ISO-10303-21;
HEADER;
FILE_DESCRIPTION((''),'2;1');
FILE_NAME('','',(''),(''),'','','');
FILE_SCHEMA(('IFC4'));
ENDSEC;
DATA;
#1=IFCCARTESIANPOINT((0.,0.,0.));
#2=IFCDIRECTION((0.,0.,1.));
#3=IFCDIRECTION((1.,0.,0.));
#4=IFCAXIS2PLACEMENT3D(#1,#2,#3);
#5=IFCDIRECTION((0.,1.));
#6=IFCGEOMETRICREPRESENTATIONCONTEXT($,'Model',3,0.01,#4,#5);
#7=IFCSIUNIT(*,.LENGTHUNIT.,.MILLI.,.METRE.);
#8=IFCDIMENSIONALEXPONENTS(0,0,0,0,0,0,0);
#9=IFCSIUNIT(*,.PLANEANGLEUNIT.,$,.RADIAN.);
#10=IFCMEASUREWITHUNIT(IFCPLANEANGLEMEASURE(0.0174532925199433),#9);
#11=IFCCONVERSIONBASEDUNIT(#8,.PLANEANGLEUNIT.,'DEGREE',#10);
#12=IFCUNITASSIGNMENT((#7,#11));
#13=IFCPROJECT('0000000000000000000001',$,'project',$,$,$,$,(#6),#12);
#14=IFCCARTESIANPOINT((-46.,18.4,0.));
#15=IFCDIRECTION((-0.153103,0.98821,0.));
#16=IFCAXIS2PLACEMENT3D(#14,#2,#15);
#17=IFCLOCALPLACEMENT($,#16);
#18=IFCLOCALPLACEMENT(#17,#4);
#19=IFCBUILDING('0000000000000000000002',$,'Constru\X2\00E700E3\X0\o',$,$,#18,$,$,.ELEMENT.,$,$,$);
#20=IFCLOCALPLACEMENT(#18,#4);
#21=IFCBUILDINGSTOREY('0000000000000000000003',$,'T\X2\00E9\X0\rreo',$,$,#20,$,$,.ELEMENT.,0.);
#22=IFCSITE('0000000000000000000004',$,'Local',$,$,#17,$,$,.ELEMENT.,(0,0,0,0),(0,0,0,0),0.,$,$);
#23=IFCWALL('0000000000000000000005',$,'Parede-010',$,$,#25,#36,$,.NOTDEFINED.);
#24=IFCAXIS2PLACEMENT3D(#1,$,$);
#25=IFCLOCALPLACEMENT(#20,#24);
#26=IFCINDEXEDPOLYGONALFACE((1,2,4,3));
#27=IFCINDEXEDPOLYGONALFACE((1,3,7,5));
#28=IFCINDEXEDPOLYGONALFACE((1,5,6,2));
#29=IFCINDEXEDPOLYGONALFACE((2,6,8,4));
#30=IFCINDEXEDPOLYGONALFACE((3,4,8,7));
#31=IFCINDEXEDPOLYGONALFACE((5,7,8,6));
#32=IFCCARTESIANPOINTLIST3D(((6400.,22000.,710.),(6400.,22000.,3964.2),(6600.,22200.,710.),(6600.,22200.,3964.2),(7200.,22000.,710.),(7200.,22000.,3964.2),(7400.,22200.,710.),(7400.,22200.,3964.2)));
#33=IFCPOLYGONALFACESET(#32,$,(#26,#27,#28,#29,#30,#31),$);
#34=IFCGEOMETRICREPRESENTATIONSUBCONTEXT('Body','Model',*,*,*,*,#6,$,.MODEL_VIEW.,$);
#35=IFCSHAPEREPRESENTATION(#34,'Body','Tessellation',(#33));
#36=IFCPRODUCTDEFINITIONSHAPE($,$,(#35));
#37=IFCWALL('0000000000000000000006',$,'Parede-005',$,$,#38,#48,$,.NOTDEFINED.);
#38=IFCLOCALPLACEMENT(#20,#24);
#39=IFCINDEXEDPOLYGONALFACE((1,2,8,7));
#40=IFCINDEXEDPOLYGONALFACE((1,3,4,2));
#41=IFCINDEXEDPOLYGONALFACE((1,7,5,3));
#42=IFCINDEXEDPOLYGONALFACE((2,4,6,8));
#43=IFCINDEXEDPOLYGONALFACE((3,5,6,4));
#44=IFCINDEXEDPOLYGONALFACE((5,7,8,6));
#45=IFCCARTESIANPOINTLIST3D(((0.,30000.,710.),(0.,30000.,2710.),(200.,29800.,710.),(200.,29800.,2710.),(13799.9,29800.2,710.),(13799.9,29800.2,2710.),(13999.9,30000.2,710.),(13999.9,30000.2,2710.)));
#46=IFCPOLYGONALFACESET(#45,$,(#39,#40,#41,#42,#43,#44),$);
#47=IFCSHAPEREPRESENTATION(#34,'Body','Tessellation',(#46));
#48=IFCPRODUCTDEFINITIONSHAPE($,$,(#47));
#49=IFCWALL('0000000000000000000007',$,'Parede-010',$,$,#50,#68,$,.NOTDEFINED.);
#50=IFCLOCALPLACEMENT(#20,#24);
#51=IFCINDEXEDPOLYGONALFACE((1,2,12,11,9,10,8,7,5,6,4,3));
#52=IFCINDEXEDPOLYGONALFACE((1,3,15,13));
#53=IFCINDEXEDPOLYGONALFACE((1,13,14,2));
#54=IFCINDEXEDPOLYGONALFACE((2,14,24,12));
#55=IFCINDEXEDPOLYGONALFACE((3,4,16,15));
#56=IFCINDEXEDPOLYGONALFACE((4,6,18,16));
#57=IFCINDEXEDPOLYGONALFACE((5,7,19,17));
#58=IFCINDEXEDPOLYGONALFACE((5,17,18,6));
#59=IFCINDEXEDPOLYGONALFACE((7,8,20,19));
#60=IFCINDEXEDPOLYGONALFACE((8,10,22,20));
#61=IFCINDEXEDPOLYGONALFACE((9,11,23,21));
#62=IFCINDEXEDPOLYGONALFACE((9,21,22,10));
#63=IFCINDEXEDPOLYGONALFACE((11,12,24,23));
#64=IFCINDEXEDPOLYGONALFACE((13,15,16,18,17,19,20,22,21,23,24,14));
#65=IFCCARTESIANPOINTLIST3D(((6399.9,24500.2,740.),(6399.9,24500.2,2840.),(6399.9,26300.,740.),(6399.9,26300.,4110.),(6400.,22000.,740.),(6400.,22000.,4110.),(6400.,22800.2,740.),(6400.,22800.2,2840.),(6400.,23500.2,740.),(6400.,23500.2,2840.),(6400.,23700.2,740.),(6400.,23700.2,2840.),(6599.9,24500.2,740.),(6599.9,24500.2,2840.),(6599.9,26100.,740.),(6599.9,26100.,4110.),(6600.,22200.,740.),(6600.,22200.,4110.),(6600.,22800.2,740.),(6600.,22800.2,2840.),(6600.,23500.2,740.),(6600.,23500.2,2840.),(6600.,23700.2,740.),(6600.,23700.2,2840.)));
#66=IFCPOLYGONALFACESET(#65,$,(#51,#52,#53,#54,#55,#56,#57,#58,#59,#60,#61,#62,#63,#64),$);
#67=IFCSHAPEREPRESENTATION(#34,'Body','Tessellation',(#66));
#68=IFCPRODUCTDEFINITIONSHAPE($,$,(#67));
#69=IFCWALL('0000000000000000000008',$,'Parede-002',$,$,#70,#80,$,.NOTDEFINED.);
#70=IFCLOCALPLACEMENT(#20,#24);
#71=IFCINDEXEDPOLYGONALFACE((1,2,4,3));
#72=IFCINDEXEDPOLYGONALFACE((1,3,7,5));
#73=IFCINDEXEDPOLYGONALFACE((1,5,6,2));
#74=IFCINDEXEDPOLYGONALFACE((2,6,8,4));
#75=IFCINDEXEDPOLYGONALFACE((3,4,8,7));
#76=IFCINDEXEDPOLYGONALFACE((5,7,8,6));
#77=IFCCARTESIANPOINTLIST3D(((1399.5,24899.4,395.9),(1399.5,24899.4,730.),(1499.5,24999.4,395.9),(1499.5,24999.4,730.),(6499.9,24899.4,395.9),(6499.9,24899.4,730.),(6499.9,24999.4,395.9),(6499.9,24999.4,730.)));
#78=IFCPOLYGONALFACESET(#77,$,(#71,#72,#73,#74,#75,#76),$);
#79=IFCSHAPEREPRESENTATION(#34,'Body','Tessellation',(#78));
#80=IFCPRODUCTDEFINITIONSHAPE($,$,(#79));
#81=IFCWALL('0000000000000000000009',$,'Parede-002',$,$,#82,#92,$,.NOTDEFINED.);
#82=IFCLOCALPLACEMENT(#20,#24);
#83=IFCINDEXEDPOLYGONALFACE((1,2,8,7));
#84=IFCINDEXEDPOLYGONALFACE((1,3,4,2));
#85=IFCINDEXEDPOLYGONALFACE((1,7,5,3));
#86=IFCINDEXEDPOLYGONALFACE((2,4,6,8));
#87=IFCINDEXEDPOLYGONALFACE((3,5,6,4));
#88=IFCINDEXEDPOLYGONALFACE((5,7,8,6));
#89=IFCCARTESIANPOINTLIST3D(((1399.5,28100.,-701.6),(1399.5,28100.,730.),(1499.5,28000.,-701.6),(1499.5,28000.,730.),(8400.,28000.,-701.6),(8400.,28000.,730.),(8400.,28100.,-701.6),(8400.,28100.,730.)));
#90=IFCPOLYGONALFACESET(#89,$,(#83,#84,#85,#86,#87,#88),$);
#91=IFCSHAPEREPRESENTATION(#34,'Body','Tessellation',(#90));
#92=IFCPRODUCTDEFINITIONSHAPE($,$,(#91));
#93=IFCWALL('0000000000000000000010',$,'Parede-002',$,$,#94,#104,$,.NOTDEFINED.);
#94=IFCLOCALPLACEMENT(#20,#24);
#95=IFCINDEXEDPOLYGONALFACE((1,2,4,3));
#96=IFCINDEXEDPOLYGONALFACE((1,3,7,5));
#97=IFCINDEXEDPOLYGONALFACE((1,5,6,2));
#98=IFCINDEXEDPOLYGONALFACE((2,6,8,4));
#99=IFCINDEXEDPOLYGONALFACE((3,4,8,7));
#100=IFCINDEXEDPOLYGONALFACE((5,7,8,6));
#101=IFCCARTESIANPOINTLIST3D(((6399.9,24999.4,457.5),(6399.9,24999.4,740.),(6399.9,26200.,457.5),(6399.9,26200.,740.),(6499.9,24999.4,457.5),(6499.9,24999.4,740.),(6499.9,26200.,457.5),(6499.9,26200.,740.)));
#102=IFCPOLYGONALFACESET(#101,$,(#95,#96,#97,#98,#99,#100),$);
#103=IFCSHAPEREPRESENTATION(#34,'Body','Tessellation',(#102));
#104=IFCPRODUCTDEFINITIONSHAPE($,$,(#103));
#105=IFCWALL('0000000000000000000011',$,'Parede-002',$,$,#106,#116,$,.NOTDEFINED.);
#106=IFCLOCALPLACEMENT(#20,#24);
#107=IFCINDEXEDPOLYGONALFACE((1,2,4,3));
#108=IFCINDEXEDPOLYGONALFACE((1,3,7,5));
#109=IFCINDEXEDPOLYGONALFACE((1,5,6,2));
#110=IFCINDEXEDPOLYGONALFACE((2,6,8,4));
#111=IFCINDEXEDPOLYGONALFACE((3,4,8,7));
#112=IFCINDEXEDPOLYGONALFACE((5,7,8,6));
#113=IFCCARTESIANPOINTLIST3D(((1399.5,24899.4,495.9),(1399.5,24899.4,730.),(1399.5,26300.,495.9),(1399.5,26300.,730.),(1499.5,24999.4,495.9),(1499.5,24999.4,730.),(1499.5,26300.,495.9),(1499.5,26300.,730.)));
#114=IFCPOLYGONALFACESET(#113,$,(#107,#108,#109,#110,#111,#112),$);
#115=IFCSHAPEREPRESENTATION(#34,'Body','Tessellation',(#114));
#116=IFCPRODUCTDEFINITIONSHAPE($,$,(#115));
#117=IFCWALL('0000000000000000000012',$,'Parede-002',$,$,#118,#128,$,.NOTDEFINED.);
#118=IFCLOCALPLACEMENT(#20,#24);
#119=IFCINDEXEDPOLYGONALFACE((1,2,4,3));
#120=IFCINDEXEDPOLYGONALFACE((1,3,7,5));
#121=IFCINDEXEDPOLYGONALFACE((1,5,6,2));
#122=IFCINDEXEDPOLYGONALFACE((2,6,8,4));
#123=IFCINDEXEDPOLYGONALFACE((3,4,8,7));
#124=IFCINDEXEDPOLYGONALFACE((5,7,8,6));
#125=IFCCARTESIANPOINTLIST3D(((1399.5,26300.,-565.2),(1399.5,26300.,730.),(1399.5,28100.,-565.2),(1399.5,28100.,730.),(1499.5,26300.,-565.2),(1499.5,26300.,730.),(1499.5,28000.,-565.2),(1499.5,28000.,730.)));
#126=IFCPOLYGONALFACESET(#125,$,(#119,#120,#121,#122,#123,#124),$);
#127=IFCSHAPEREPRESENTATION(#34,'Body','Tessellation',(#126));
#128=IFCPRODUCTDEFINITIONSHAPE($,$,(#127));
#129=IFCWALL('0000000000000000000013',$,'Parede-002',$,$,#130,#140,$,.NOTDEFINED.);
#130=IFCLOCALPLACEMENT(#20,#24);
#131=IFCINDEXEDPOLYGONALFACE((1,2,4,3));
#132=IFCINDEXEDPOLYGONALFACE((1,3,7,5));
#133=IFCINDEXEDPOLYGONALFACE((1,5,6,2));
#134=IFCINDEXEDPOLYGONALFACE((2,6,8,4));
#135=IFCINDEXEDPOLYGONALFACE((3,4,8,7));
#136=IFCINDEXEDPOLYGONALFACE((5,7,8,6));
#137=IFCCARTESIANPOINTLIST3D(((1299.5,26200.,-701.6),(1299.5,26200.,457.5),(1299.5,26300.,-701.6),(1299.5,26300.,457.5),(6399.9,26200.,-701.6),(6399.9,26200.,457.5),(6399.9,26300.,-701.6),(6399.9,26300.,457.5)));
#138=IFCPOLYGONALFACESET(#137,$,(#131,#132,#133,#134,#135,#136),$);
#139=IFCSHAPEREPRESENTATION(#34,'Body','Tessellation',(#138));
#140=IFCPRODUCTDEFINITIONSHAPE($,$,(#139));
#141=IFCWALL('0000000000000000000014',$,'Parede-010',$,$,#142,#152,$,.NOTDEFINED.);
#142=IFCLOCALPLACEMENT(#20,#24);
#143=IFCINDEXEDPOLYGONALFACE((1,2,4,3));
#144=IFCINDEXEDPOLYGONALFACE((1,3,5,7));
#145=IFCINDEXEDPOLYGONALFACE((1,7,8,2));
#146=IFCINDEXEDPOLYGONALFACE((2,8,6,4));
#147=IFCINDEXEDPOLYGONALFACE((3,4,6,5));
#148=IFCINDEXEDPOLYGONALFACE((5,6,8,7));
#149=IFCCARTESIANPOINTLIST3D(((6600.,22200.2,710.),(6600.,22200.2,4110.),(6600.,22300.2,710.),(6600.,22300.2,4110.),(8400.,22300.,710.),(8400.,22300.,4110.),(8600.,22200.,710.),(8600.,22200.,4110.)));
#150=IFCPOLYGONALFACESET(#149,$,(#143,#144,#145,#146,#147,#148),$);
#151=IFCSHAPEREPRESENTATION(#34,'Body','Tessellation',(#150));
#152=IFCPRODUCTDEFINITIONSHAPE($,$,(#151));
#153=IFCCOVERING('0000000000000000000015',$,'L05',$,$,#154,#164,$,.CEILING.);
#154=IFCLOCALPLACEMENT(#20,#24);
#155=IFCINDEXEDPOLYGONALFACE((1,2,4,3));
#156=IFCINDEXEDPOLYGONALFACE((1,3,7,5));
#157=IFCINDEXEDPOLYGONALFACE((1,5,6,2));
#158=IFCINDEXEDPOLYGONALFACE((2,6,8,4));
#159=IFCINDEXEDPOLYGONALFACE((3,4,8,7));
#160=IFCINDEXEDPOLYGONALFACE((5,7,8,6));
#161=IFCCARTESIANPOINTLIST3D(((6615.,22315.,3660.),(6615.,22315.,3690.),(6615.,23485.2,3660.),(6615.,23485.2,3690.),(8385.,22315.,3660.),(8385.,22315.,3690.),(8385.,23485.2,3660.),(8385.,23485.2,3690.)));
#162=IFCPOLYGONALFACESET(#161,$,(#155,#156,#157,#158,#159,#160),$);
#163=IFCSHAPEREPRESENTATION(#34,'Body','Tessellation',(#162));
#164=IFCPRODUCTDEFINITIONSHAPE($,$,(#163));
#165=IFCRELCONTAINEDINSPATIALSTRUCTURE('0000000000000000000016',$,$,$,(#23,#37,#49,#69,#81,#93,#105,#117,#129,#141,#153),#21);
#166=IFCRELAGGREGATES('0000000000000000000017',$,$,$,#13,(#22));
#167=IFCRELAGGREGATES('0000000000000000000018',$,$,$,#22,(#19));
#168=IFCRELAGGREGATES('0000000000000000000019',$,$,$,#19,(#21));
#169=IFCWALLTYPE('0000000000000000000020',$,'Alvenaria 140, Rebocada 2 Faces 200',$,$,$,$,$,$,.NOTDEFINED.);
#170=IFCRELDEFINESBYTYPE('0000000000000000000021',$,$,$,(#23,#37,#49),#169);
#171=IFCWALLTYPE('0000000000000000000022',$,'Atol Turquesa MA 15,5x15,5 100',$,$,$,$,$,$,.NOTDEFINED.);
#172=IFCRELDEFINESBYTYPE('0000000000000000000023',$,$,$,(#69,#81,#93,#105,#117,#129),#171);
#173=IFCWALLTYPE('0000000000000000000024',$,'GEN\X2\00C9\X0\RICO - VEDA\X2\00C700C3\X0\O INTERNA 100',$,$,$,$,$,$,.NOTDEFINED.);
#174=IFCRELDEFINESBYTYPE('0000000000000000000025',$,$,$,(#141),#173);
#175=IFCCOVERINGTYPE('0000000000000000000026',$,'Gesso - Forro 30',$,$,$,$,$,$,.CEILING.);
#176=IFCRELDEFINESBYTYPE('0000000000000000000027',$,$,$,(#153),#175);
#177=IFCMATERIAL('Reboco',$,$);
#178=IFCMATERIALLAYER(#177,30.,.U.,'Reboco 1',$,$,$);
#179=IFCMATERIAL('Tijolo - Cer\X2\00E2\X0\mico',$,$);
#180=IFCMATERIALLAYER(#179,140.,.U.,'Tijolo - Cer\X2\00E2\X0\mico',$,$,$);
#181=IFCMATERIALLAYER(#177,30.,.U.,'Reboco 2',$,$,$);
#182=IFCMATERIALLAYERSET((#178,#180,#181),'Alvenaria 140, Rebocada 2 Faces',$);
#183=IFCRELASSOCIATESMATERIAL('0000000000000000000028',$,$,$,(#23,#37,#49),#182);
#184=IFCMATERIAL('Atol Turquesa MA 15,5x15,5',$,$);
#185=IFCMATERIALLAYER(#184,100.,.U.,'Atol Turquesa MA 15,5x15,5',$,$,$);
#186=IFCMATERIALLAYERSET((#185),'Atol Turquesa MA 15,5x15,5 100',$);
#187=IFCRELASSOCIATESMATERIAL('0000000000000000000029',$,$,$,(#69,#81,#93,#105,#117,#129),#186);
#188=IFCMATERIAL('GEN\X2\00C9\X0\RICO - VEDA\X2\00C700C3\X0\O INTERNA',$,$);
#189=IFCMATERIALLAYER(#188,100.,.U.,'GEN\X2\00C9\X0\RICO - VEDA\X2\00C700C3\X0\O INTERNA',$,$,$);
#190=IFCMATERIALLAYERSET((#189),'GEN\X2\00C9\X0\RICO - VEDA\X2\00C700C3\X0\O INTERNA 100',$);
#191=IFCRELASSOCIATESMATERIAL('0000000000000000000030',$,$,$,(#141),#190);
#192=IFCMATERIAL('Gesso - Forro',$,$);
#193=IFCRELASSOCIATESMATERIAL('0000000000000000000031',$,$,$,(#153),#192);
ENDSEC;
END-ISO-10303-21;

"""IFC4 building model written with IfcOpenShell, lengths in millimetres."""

from ifc_helpers import new_model, entity, si_unit, converted_unit, direction, frame, origin_with_axes, origin_2d_with_axis, place, context, subcontext, project, spatial, line, indexed_curve, rectangle, outline, extrude, material, layer, layer_set, layer_usage, type_object, element, save


model = new_model("IFC4")

# Units and contexts
model_context = context("Model", 3, precision=0.01, world=origin_with_axes(), true_north=direction((0.0, 1.0)))
body_context = subcontext(model_context, "Body", "Model", "MODEL_VIEW")
ifc_project = project(units=[si_unit("LENGTHUNIT", "METRE", prefix="MILLI"), converted_unit("PLANEANGLEUNIT", "DEGREE", entity("IfcPlaneAngleMeasure", 0.0174532925199433), si_unit("PLANEANGLEUNIT", "RADIAN"), dimensions=[0, 0, 0, 0, 0, 0, 0])], contexts=[model_context])

# Site, building, storey
site_placement = place(None, frame((-46.0, 18.4, 0.0), z_axis=(0.0, 0.0, 1.0), x_axis=(-0.153103, 0.98821, 0.0)))
site = spatial("IfcSite", under=ifc_project, at=site_placement, Name="Local", CompositionType="ELEMENT", RefLatitude=(0, 0, 0, 0), RefLongitude=(0, 0, 0, 0), RefElevation=0.0)
building_placement = place(site_placement, origin_with_axes())
building = spatial("IfcBuilding", under=site, at=building_placement, Name="Construção", CompositionType="ELEMENT")
storey_placement = place(building_placement, origin_with_axes())
storey = spatial("IfcBuildingStorey", under=building, at=storey_placement, Name="Térreo", CompositionType="ELEMENT", Elevation=0.0)

# Walls
ifc_material_1 = material(Name="Reboco")
ifc_layer_1 = layer(ifc_material_1, 30.0, ventilated="UNKNOWN", Name="Reboco 1")
ifc_material_2 = material(Name="Tijolo - Cerâmico")
ifc_layer_2 = layer(ifc_material_2, 140.0, ventilated="UNKNOWN", Name="Tijolo - Cerâmico")
ifc_layer_3 = layer(ifc_material_1, 30.0, ventilated="UNKNOWN", Name="Reboco 2")
ifc_layer_set_1 = layer_set([ifc_layer_1, ifc_layer_2, ifc_layer_3], Name="Alvenaria 140, Rebocada 2 Faces")
wall_type_1 = type_object("IfcWallType", Name="Alvenaria 140, Rebocada 2 Faces 200", PredefinedType="NOTDEFINED")
ifc_layer_usage_1 = layer_usage(ifc_layer_set_1, "AXIS2", "POSITIVE", 0.0)
wall_1_placement = place(storey_placement, frame((6400.0, 22000.0, 710.0), z_axis=(0.0, 0.0, 1.0), x_axis=(1.0, 0.0, 0.0)))
element("IfcWall", 1, at=wall_1_placement, inside=storey, type_object=wall_type_1, material=ifc_layer_usage_1, Name="Parede-010", PredefinedType="NOTDEFINED", context=body_context, shape_type="SweptSolid", body=[
    extrude(outline(indexed_curve([(0.0, 0.0), (800.0, 0.0), (1000.0, 200.0), (200.0, 200.0)], segments=[line(1, 2, 3, 4, 1)])), origin_with_axes(), (0.0, 0.0, 1.0), 3254.2),
])
ifc_layer_usage_2 = layer_usage(ifc_layer_set_1, "AXIS2", "NEGATIVE", 0.0)
wall_2_placement = place(storey_placement, frame((0.0, 30000.0, 710.0), z_axis=(0.0, 0.0, 1.0), x_axis=(1.0, 0.000018, 0.0)))
element("IfcWall", 2, at=wall_2_placement, inside=storey, type_object=wall_type_1, material=ifc_layer_usage_2, Name="Parede-005", PredefinedType="NOTDEFINED", context=body_context, shape_type="SweptSolid", body=[
    extrude(outline(indexed_curve([(200.0, -200.0), (13799.9, -200.0), (13999.9, 0.0), (0.0, 0.0)], segments=[line(1, 2, 3, 4, 1)])), origin_with_axes(), (0.0, 0.0, 1.0), 2000.0),
])

# Wall, openings
ifc_layer_usage_3 = layer_usage(ifc_layer_set_1, "AXIS2", "POSITIVE", 0.0)
wall_3_placement = place(storey_placement, frame((6399.9, 26300.0, 740.0), z_axis=(0.0, 0.0, 1.0), x_axis=(0.000013, -1.0, 0.0)))
wall_3 = element("IfcWall", 3, at=wall_3_placement, inside=storey, type_object=wall_type_1, material=ifc_layer_usage_3, Name="Parede-010", PredefinedType="NOTDEFINED", context=body_context, shape_type="SweptSolid", body=[
    extrude(outline(indexed_curve([(0.0, 0.0), (4300.0, 0.0), (4100.0, 200.0), (200.0, 200.0)], segments=[line(1, 2, 3, 4, 1)])), origin_with_axes(), (0.0, 0.0, 1.0), 3370.0),
])
opening_1_placement = place(wall_3_placement, frame((3149.8, 0.0, 0.0), z_axis=(0.0, 0.0, 1.0), x_axis=(1.0, 0.0, 0.0)))
element("IfcOpeningElement", 4, at=opening_1_placement, cuts=wall_3, context=body_context, shape_type="SweptSolid", body=[
    extrude(rectangle(XDim=700.0, YDim=2100.0, at=origin_2d_with_axis()), frame((0.0, 200.0, 1050.0), z_axis=(0.0, 1.0, 0.0), x_axis=(-1.0, 0.0, 0.0)), (0.0, 0.0, -1.0), 600.0),
])
opening_2_placement = place(wall_3_placement, frame((2199.8, 0.0, 0.0), z_axis=(0.0, 0.0, 1.0), x_axis=(1.0, 0.0, 0.0)))
element("IfcOpeningElement", 5, at=opening_2_placement, cuts=wall_3, context=body_context, shape_type="SweptSolid", body=[
    extrude(rectangle(XDim=800.0, YDim=2100.0, at=origin_2d_with_axis()), frame((0.0, 200.0, 1050.0), z_axis=(0.0, -1.0, 0.0), x_axis=(1.0, 0.0, 0.0)), (0.0, 0.0, 1.0), 600.0),
])

# Walls
ifc_material_3 = material(Name="Atol Turquesa MA 15,5x15,5")
ifc_layer_4 = layer(ifc_material_3, 100.0, ventilated="UNKNOWN", Name="Atol Turquesa MA 15,5x15,5")
ifc_layer_set_2 = layer_set([ifc_layer_4], Name="Atol Turquesa MA 15,5x15,5 100")
ifc_layer_usage_4 = layer_usage(ifc_layer_set_2, "AXIS2", "NEGATIVE", 0.0)
wall_type_2 = type_object("IfcWallType", Name="Atol Turquesa MA 15,5x15,5 100", PredefinedType="NOTDEFINED")
wall_4_placement = place(storey_placement, frame((6499.9, 24899.4, 395.9), z_axis=(0.0, 0.0, 1.0), x_axis=(-1.0, 0.0, 0.0)))
element("IfcWall", 6, at=wall_4_placement, inside=storey, type_object=wall_type_2, material=ifc_layer_usage_4, Name="Parede-002", PredefinedType="NOTDEFINED", context=body_context, shape_type="SweptSolid", body=[
    extrude(outline(indexed_curve([(0.0, -100.0), (5000.4, -100.0), (5100.4, 0.0), (0.0, 0.0)], segments=[line(1, 2, 3, 4, 1)])), origin_with_axes(), (0.0, 0.0, 1.0), 334.1),
])
ifc_layer_usage_5 = layer_usage(ifc_layer_set_2, "AXIS2", "NEGATIVE", 0.0)
wall_5_placement = place(storey_placement, frame((1399.5, 28100.0, -701.6), z_axis=(0.0, 0.0, 1.0), x_axis=(1.0, 0.0, 0.0)))
element("IfcWall", 7, at=wall_5_placement, inside=storey, type_object=wall_type_2, material=ifc_layer_usage_5, Name="Parede-002", PredefinedType="NOTDEFINED", context=body_context, shape_type="SweptSolid", body=[
    extrude(outline(indexed_curve([(100.0, -100.0), (7000.5, -100.0), (7000.5, 0.0), (0.0, 0.0)], segments=[line(1, 2, 3, 4, 1)])), origin_with_axes(), (0.0, 0.0, 1.0), 1431.6),
])
ifc_layer_usage_6 = layer_usage(ifc_layer_set_2, "AXIS2", "NEGATIVE", 0.0)
wall_6_placement = place(storey_placement, frame((6499.9, 26200.0, 457.5), z_axis=(0.0, 0.0, 1.0), x_axis=(0.0, -1.0, 0.0)))
element("IfcWall", 8, at=wall_6_placement, inside=storey, type_object=wall_type_2, material=ifc_layer_usage_6, Name="Parede-002", PredefinedType="NOTDEFINED", context=body_context, shape_type="SweptSolid", body=[
    extrude(outline(indexed_curve([(0.0, -100.0), (1200.6, -100.0), (1200.6, 0.0), (0.0, 0.0)], segments=[line(1, 2, 3, 4, 1)])), origin_with_axes(), (0.0, 0.0, 1.0), 282.5),
])
ifc_layer_usage_7 = layer_usage(ifc_layer_set_2, "AXIS2", "NEGATIVE", 0.0)
wall_7_placement = place(storey_placement, frame((1399.5, 24899.4, 495.9), z_axis=(0.0, 0.0, 1.0), x_axis=(0.0, 1.0, 0.0)))
element("IfcWall", 9, at=wall_7_placement, inside=storey, type_object=wall_type_2, material=ifc_layer_usage_7, Name="Parede-002", PredefinedType="NOTDEFINED", context=body_context, shape_type="SweptSolid", body=[
    extrude(outline(indexed_curve([(100.0, -100.0), (1400.6, -100.0), (1400.6, 0.0), (0.0, 0.0)], segments=[line(1, 2, 3, 4, 1)])), origin_with_axes(), (0.0, 0.0, 1.0), 234.1),
])
ifc_layer_usage_8 = layer_usage(ifc_layer_set_2, "AXIS2", "NEGATIVE", 0.0)
wall_8_placement = place(storey_placement, frame((1399.5, 26300.0, -565.2), z_axis=(0.0, 0.0, 1.0), x_axis=(0.0, 1.0, 0.0)))
element("IfcWall", 10, at=wall_8_placement, inside=storey, type_object=wall_type_2, material=ifc_layer_usage_8, Name="Parede-002", PredefinedType="NOTDEFINED", context=body_context, shape_type="SweptSolid", body=[
    extrude(outline(indexed_curve([(0.0, -100.0), (1700.0, -100.0), (1800.0, 0.0), (0.0, 0.0)], segments=[line(1, 2, 3, 4, 1)])), origin_with_axes(), (0.0, 0.0, 1.0), 1295.2),
])
ifc_layer_usage_9 = layer_usage(ifc_layer_set_2, "AXIS2", "NEGATIVE", 0.0)
wall_9_placement = place(storey_placement, frame((6399.9, 26200.0, -701.6), z_axis=(0.0, 0.0, 1.0), x_axis=(-1.0, 0.0, 0.0)))
element("IfcWall", 11, at=wall_9_placement, inside=storey, type_object=wall_type_2, material=ifc_layer_usage_9, Name="Parede-002", PredefinedType="NOTDEFINED", context=body_context, shape_type="SweptSolid", body=[
    extrude(outline(indexed_curve([(0.0, -100.0), (5100.5, -100.0), (5100.5, 0.0), (0.0, 0.0)], segments=[line(1, 2, 3, 4, 1)])), origin_with_axes(), (0.0, 0.0, 1.0), 1159.1),
])
ifc_material_4 = material(Name="GENÉRICO - VEDAÇÃO INTERNA")
ifc_layer_5 = layer(ifc_material_4, 100.0, ventilated="UNKNOWN", Name="GENÉRICO - VEDAÇÃO INTERNA")
ifc_layer_set_3 = layer_set([ifc_layer_5], Name="GENÉRICO - VEDAÇÃO INTERNA 100")
ifc_layer_usage_10 = layer_usage(ifc_layer_set_3, "AXIS2", "POSITIVE", 0.0)
wall_type_3 = type_object("IfcWallType", Name="GENÉRICO - VEDAÇÃO INTERNA 100", PredefinedType="NOTDEFINED")
wall_10_placement = place(storey_placement, frame((6400.0, 22200.2, 710.0), z_axis=(0.0, 0.0, 1.0), x_axis=(1.0, -0.000083, 0.0)))
element("IfcWall", 12, at=wall_10_placement, inside=storey, type_object=wall_type_3, material=ifc_layer_usage_10, Name="Parede-010", PredefinedType="NOTDEFINED", context=body_context, shape_type="SweptSolid", body=[
    extrude(outline(indexed_curve([(200.0, 0.0), (2200.0, 0.0), (2000.0, 100.0), (200.0, 100.0)], segments=[line(1, 2, 3, 4, 1)])), origin_with_axes(), (0.0, 0.0, 1.0), 3400.0),
])

# Covering
ifc_material_5 = material(Name="Gesso - Forro")
covering_type = type_object("IfcCoveringType", Name="Gesso - Forro 30", PredefinedType="CEILING")
covering_1_placement = place(storey_placement, frame((6615.0, 22315.0, 3690.0), z_axis=(0.0, 0.0, 1.0), x_axis=(1.0, 0.0, 0.0)))
element("IfcCovering", 13, at=covering_1_placement, inside=storey, type_object=covering_type, material=ifc_material_5, Name="L05", PredefinedType="CEILING", context=body_context, shape_type="SweptSolid", body=[
    extrude(outline(indexed_curve([(0.0, 0.0), (1770.0, 0.0), (1770.0, 1170.2), (0.0, 1170.2)], segments=[line(1, 2, 3, 4, 1)])), frame((0.0, 0.0, -30.0), z_axis=(0.0, 0.0, 1.0), x_axis=(1.0, 0.0, 0.0)), (0.0, 0.0, 1.0), 30.0),
])

save(model, "model.ifc")
